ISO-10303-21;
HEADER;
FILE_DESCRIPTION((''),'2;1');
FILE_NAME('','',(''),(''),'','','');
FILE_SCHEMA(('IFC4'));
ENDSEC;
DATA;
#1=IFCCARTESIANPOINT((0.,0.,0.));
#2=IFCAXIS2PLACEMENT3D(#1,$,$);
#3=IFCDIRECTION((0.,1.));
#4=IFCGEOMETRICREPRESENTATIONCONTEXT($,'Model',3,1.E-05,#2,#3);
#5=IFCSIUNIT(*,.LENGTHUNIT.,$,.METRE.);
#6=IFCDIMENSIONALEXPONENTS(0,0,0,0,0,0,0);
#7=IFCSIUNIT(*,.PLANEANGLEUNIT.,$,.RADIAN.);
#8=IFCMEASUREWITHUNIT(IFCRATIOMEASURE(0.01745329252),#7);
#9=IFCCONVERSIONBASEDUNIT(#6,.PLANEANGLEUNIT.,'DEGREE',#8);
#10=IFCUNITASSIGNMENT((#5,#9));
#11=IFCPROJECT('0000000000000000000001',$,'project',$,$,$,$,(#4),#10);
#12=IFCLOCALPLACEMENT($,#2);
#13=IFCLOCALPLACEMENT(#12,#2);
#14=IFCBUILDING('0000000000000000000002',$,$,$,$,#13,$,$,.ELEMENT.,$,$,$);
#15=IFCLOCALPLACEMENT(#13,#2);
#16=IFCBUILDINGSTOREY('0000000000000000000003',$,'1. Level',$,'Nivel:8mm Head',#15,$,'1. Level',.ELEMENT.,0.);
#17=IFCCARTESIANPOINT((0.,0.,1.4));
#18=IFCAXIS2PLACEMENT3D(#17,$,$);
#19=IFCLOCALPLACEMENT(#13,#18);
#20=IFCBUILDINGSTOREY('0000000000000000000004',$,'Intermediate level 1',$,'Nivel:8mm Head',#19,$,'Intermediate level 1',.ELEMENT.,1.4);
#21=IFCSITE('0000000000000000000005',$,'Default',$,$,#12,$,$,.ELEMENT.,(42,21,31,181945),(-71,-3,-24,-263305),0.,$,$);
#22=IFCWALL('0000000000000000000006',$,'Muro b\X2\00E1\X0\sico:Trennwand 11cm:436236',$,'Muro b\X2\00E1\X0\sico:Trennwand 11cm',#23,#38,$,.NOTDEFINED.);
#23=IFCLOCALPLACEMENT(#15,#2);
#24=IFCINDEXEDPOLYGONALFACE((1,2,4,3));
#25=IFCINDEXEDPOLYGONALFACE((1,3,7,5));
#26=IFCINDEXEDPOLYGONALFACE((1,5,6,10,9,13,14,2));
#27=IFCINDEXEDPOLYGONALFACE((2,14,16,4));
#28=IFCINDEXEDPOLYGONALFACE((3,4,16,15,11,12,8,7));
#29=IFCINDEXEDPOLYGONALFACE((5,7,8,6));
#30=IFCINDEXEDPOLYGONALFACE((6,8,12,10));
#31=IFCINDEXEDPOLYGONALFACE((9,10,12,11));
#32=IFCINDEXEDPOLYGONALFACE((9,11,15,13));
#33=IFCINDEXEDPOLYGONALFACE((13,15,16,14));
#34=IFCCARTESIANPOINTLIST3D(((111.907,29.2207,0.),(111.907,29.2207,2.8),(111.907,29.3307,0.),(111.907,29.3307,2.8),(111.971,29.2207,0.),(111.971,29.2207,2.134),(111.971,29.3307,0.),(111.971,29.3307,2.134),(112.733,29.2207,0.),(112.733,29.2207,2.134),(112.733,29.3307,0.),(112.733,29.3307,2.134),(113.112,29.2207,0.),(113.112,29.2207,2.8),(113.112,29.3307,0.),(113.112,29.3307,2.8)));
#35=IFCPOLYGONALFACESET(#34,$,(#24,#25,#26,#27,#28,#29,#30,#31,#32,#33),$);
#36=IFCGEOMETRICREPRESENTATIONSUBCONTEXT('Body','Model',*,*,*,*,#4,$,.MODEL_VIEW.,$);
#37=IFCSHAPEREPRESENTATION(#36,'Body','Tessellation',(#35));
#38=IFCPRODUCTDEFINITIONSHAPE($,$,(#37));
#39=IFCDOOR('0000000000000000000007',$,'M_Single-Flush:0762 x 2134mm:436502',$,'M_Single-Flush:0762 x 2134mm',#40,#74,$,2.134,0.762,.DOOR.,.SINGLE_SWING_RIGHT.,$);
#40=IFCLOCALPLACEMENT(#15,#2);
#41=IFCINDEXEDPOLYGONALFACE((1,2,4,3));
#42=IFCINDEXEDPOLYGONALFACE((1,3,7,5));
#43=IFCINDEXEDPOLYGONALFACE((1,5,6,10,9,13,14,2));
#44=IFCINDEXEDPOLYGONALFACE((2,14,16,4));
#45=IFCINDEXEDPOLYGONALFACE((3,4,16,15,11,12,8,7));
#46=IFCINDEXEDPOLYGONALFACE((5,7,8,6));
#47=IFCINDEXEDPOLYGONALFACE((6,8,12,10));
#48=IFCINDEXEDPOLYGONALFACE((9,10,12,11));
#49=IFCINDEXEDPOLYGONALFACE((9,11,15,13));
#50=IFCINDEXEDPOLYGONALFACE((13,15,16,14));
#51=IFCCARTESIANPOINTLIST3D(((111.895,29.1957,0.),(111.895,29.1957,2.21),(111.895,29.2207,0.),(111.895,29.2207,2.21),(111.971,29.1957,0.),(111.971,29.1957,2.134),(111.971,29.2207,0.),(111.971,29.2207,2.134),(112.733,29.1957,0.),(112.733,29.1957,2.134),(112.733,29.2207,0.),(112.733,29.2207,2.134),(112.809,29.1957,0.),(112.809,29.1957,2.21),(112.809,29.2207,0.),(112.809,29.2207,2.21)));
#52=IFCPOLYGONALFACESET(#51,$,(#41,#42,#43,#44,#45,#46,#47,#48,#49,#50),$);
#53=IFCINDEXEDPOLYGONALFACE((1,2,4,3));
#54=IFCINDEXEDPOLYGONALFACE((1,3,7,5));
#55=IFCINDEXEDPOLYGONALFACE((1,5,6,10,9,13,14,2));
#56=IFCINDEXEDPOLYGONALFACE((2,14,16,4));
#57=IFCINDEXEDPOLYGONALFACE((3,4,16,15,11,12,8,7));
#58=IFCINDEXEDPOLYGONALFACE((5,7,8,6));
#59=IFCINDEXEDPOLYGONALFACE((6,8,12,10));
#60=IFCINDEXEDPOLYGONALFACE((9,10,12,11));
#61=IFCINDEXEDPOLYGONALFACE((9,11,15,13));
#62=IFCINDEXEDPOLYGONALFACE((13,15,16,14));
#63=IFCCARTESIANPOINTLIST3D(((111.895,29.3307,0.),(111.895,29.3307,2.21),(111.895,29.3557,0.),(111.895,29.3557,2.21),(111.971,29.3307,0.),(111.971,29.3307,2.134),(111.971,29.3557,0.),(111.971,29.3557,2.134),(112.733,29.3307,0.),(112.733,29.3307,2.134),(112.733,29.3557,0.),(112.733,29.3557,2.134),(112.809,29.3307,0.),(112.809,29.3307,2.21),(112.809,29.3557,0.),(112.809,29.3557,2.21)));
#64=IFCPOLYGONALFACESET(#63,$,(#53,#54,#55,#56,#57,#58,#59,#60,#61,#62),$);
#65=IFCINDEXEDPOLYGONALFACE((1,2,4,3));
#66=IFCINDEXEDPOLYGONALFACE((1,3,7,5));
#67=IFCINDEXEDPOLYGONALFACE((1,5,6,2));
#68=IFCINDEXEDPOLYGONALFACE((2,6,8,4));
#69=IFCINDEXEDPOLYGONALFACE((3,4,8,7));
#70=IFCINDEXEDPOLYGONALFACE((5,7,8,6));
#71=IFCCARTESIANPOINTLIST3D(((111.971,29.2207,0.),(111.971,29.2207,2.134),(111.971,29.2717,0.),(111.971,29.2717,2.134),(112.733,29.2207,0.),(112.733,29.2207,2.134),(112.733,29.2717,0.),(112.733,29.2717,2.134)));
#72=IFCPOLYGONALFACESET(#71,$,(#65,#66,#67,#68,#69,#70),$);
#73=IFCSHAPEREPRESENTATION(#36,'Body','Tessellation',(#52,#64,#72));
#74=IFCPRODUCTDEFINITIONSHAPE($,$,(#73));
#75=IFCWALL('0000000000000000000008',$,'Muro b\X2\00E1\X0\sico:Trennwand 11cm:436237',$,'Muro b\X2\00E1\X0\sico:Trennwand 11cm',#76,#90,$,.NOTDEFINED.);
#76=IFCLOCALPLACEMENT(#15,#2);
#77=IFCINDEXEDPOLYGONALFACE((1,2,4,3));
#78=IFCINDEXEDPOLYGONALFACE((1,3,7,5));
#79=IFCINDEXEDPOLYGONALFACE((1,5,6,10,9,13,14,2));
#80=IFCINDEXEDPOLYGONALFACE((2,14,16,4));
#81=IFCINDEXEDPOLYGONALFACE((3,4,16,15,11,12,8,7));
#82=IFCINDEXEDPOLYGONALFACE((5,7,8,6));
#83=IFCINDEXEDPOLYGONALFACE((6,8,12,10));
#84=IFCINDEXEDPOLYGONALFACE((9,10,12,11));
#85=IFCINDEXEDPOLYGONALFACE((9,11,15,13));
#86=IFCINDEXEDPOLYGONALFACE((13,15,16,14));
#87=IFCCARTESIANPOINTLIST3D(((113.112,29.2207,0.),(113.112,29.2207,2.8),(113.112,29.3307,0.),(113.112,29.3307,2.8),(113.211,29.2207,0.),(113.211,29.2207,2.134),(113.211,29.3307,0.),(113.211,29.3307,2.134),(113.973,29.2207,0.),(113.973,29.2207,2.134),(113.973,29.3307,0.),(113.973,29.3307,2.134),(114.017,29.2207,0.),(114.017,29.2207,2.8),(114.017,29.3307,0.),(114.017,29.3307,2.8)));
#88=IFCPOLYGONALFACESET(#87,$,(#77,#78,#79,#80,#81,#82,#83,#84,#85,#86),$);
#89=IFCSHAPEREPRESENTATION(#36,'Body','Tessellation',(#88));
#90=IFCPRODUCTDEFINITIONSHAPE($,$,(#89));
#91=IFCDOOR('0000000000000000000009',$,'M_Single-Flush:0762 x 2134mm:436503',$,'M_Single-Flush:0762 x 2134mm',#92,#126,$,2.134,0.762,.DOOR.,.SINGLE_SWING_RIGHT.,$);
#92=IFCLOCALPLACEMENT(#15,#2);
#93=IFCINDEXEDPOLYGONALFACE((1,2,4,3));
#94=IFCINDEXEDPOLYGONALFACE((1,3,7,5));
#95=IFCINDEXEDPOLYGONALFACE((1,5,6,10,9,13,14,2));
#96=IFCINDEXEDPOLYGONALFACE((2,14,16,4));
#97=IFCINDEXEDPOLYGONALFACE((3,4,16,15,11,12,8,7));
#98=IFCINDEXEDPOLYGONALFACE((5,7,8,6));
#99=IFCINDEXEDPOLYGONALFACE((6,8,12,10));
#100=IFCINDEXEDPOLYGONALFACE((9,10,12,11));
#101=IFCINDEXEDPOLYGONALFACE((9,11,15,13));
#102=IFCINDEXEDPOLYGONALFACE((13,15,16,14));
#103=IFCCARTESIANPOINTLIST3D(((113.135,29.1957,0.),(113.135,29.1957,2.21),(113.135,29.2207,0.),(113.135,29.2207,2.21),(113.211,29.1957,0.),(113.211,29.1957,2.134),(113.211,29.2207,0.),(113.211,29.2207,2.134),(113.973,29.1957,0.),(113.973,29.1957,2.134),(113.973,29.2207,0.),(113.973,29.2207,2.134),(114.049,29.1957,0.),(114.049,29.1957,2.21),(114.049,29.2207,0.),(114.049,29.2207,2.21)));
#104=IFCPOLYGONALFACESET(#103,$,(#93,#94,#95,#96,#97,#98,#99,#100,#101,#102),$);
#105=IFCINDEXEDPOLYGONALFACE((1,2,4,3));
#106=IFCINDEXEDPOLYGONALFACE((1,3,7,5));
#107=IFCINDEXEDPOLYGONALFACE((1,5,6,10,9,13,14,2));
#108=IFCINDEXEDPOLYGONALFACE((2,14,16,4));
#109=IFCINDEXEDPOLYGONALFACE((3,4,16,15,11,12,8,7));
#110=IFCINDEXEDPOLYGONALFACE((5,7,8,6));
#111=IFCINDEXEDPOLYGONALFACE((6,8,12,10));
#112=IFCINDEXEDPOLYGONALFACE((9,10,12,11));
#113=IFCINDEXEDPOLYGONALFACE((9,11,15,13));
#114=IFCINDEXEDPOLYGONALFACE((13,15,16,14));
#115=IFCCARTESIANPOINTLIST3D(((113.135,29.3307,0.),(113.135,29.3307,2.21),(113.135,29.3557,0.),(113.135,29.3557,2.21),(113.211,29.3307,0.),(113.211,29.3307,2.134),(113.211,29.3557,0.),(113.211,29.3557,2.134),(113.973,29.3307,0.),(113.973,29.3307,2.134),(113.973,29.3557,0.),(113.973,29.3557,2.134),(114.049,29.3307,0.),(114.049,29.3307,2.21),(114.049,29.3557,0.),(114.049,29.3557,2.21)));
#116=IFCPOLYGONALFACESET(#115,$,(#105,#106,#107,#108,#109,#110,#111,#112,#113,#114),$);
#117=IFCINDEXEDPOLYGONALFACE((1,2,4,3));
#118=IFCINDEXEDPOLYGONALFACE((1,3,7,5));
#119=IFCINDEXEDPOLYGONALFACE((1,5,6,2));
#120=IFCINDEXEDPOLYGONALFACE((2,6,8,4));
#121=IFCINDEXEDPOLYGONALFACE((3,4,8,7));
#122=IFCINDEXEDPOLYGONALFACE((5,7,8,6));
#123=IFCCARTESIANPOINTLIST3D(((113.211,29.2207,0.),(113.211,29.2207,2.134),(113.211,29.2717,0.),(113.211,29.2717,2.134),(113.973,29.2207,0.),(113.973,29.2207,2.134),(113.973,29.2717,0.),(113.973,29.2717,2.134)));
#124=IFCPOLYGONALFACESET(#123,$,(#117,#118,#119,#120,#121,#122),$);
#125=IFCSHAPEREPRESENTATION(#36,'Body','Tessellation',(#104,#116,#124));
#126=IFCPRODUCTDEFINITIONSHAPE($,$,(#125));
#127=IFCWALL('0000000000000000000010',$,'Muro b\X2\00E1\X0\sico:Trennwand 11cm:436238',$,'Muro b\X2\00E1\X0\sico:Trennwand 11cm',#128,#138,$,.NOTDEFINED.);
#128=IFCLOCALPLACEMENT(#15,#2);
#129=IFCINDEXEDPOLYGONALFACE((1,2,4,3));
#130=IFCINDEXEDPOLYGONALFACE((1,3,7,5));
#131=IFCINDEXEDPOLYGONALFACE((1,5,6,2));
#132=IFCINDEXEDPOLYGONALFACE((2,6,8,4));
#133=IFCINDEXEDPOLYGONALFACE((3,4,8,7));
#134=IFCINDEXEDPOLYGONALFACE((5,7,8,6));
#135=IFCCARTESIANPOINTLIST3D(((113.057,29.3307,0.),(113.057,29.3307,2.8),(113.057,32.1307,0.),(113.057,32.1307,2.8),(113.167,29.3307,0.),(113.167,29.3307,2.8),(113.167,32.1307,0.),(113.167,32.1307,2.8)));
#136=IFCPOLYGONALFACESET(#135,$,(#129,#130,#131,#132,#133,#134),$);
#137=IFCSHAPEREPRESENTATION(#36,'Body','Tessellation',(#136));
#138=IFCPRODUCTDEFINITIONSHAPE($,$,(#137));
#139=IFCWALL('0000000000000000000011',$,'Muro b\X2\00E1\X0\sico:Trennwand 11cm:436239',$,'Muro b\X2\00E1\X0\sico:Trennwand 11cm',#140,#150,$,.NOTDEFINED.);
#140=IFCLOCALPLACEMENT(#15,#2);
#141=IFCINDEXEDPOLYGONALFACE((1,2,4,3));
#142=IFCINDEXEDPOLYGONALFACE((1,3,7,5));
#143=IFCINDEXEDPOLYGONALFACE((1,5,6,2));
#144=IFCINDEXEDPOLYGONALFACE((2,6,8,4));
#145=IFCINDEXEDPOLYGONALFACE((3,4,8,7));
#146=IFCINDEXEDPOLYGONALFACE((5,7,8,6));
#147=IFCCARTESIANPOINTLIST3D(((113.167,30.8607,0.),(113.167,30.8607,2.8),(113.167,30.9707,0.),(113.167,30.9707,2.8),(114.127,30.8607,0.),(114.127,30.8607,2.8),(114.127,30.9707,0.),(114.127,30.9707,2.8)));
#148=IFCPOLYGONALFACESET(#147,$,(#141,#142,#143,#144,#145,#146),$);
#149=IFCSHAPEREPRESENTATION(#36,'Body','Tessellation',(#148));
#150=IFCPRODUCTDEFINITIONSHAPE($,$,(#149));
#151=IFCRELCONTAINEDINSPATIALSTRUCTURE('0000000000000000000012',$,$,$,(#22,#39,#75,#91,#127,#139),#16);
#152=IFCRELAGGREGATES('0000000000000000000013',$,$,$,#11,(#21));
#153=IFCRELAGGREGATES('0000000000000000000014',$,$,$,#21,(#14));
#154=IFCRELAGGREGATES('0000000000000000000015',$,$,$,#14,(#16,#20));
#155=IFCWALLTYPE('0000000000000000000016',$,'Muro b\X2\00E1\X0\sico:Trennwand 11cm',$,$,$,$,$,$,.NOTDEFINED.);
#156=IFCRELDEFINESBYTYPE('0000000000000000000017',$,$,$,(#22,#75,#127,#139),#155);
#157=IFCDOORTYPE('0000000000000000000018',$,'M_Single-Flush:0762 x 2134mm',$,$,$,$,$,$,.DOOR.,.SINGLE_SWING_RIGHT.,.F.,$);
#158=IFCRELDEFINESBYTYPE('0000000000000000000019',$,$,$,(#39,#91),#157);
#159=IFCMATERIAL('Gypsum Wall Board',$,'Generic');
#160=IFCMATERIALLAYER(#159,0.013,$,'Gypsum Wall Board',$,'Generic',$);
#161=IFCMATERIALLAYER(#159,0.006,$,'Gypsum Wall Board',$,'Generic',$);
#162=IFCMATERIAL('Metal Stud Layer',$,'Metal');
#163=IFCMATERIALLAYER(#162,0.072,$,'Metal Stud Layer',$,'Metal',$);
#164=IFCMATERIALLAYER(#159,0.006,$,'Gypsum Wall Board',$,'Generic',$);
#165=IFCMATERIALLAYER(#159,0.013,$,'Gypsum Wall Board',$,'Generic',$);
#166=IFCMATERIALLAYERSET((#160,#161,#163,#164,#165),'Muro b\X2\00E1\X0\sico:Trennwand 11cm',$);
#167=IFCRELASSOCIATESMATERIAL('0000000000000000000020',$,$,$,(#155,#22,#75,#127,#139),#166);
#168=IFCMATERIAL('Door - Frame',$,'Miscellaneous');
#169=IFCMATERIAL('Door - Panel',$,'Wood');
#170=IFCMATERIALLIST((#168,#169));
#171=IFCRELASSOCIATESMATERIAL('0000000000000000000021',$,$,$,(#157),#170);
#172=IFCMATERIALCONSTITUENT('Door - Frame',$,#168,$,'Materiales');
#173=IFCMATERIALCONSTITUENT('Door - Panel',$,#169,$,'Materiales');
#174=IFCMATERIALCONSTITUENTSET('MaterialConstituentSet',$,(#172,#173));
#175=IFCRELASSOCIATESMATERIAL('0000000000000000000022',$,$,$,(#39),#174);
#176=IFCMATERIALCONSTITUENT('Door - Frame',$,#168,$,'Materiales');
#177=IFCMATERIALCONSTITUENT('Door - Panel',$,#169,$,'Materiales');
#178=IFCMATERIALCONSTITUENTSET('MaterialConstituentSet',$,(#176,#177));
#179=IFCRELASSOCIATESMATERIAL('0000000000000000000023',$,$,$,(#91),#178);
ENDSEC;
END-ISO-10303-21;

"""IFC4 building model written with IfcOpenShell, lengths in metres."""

from ifc_helpers import new_model, entity, si_unit, converted_unit, direction, frame, frame_2d, origin, origin_2d_with_axis, place, context, subcontext, project, spatial, polyline, rectangle, outline, extrude, source, transform, mapped, material, material_list, layer, layer_set, layer_usage, constituent, constituent_set, type_object, type_shapes, element, fill, save


model = new_model("IFC4")

# Units and contexts
model_context = context("Model", 3, precision=1e-05, world=origin(), true_north=direction((0.0, 1.0)))
body_context = subcontext(model_context, "Body", "Model", "MODEL_VIEW")
ifc_project = project(units=[si_unit("LENGTHUNIT", "METRE"), converted_unit("PLANEANGLEUNIT", "DEGREE", entity("IfcRatioMeasure", 0.01745329252), si_unit("PLANEANGLEUNIT", "RADIAN"), dimensions=[0, 0, 0, 0, 0, 0, 0])], contexts=[model_context])

# Site, building, storey
site_placement = place(None, origin())
site = spatial("IfcSite", under=ifc_project, at=site_placement, Name="Default", CompositionType="ELEMENT", RefLatitude=(42, 21, 31, 181945), RefLongitude=(-71, -3, -24, -263305), RefElevation=0.0)
building_placement = place(site_placement, origin())
building = spatial("IfcBuilding", under=site, at=building_placement, CompositionType="ELEMENT")
storey_1_placement = place(building_placement, origin())
storey_1 = spatial("IfcBuildingStorey", under=building, at=storey_1_placement, Name="1. Level", ObjectType="Nivel:8mm Head", LongName="1. Level", CompositionType="ELEMENT", Elevation=0.0)

# Shared definitions
storey_2_placement = place(building_placement, frame((0.0, 0.0, 1.4)))
storey_2 = spatial("IfcBuildingStorey", under=building, at=storey_2_placement, Name="Intermediate level 1", ObjectType="Nivel:8mm Head", LongName="Intermediate level 1", CompositionType="ELEMENT", Elevation=1.4)

# Shared definitions
ifc_material_1 = material(Name="Gypsum Wall Board", Category="Generic")
ifc_layer_1 = layer(ifc_material_1, 0.013, Name="Gypsum Wall Board", Category="Generic")
ifc_layer_2 = layer(ifc_material_1, 0.006, Name="Gypsum Wall Board", Category="Generic")
ifc_material_2 = material(Name="Metal Stud Layer", Category="Metal")
ifc_layer_3 = layer(ifc_material_2, 0.072, Name="Metal Stud Layer", Category="Metal")
ifc_layer_4 = layer(ifc_material_1, 0.006, Name="Gypsum Wall Board", Category="Generic")
ifc_layer_5 = layer(ifc_material_1, 0.013, Name="Gypsum Wall Board", Category="Generic")
ifc_layer_set_1 = layer_set([ifc_layer_1, ifc_layer_2, ifc_layer_3, ifc_layer_4, ifc_layer_5], Name="Muro básico:Trennwand 11cm")
wall_type_1 = type_object("IfcWallType", Name="Muro básico:Trennwand 11cm", PredefinedType="NOTDEFINED", material=ifc_layer_set_1)
ifc_material_3 = material(Name="Door - Frame", Category="Miscellaneous")
ifc_material_4 = material(Name="Door - Panel", Category="Wood")
ifc_material_list_1 = material_list([ifc_material_3, ifc_material_4])
door_type_1 = type_object("IfcDoorType", Name="M_Single-Flush:0762 x 2134mm", OperationType="SINGLE_SWING_RIGHT", ParameterTakesPrecedence=False, PredefinedType="DOOR", material=ifc_material_list_1)
shared_shape_1 = source(origin(), body_context, "Body", "SweptSolid", [
    extrude(outline(polyline([(-0.457, -1.124), (0.457, -1.124), (0.457, 1.086), (0.381, 1.086), (0.381, -1.048), (-0.381, -1.048), (-0.381, 1.086), (-0.457, 1.086), (-0.457, -1.124)])), frame((0.381, 0.11, 1.086), z_axis=(0.0, 1.0, 0.0), x_axis=(1.0, 0.0, 0.0)), (0.0, 0.0, 1.0), 0.025),
    extrude(outline(polyline([(-1.124, -0.457), (1.086, -0.457), (1.086, -0.381), (-1.048, -0.381), (-1.048, 0.381), (1.086, 0.381), (1.086, 0.457), (-1.124, 0.457), (-1.124, -0.457)])), frame((0.381, -0.025, 1.086), z_axis=(0.0, 1.0, 0.0), x_axis=(0.0, 0.0, -1.0)), (0.0, 0.0, 1.0), 0.025),
    extrude(rectangle(XDim=0.051, YDim=0.762, at=origin_2d_with_axis()), frame((0.381, 0.0845, 0.0), z_axis=(0.0, 0.0, 1.0), x_axis=(0.0, 1.0, 0.0)), (0.0, 0.0, 1.0), 2.134),
])
type_shapes(door_type_1, [shared_shape_1])

# Walls, openings, doors
ifc_layer_usage_1 = layer_usage(ifc_layer_set_1, "AXIS2", "NEGATIVE", 0.055)
wall_1_placement = place(storey_1_placement, frame((113.112, 29.2757, 0.0), z_axis=(0.0, 0.0, 1.0), x_axis=(-1.0, 0.0, 0.0)))
wall_1 = element("IfcWall", 1, at=wall_1_placement, inside=storey_1, type_object=wall_type_1, material=ifc_layer_usage_1, Name="Muro básico:Trennwand 11cm:436236", ObjectType="Muro básico:Trennwand 11cm", PredefinedType="NOTDEFINED", context=body_context, shape_type="SweptSolid", body=[
    extrude(rectangle(XDim=1.205, YDim=0.11, at=frame_2d((0.6025, 0.0), x_axis=(-1.0, 0.0))), origin(), (0.0, 0.0, 1.0), 2.8),
])
opening_1_placement = place(wall_1_placement, frame((0.379, -0.055, 0.0)))
opening_1 = element("IfcOpeningElement", 2, at=opening_1_placement, cuts=wall_1, ObjectType="Opening", PredefinedType="OPENING", context=body_context, shape_type="SweptSolid", body=[
    extrude(rectangle(XDim=0.762, YDim=2.134, at=frame_2d((1.067, 0.381), x_axis=(0.0, 1.0))), frame((0.0, 0.0, 0.0), z_axis=(0.0, 1.0, 0.0), x_axis=(0.0, 0.0, 1.0)), (0.0, 0.0, 1.0), 0.11),
])
ifc_constituent_1 = constituent(ifc_material_3, Name="Door - Frame", Category="Materiales")
ifc_constituent_2 = constituent(ifc_material_4, Name="Door - Panel", Category="Materiales")
ifc_constituent_set_1 = constituent_set(constituents=[ifc_constituent_1, ifc_constituent_2], Name="MaterialConstituentSet")
door_1_placement = place(opening_1_placement, origin())
door_1 = element("IfcDoor", 3, at=door_1_placement, inside=storey_1, type_object=door_type_1, material=ifc_constituent_set_1, Name="M_Single-Flush:0762 x 2134mm:436502", ObjectType="M_Single-Flush:0762 x 2134mm", OperationType="SINGLE_SWING_RIGHT", OverallHeight=2.134, OverallWidth=0.762, PredefinedType="DOOR", context=body_context, shape_type="MappedRepresentation", body=[
    mapped(shared_shape_1, transform((0.0, 0.0, 0.0), scale=1.0)),
])
fill(opening_1, door_1)
ifc_layer_usage_2 = layer_usage(ifc_layer_set_1, "AXIS2", "NEGATIVE", 0.055)
wall_2_placement = place(storey_1_placement, frame((113.112, 29.2757, 0.0)))
wall_2 = element("IfcWall", 4, at=wall_2_placement, inside=storey_1, type_object=wall_type_1, material=ifc_layer_usage_2, Name="Muro básico:Trennwand 11cm:436237", ObjectType="Muro básico:Trennwand 11cm", PredefinedType="NOTDEFINED", context=body_context, shape_type="SweptSolid", body=[
    extrude(rectangle(XDim=0.905, YDim=0.11, at=frame_2d((0.4525, 0.0), x_axis=(-1.0, 0.0))), origin(), (0.0, 0.0, 1.0), 2.8),
])
opening_2_placement = place(wall_2_placement, frame((0.861, 0.055, 0.0)))
opening_2 = element("IfcOpeningElement", 5, at=opening_2_placement, cuts=wall_2, ObjectType="Opening", PredefinedType="OPENING", context=body_context, shape_type="SweptSolid", body=[
    extrude(rectangle(XDim=0.762, YDim=2.134, at=frame_2d((1.067, 0.381), x_axis=(0.0, 1.0))), frame((0.0, 0.0, 0.0), z_axis=(0.0, -1.0, 0.0), x_axis=(0.0, 0.0, 1.0)), (0.0, 0.0, 1.0), 0.11),
])
ifc_constituent_3 = constituent(ifc_material_3, Name="Door - Frame", Category="Materiales")
ifc_constituent_4 = constituent(ifc_material_4, Name="Door - Panel", Category="Materiales")
ifc_constituent_set_2 = constituent_set(constituents=[ifc_constituent_3, ifc_constituent_4], Name="MaterialConstituentSet")
door_2_placement = place(opening_2_placement, frame((0.0, 0.0, 0.0), z_axis=(0.0, 0.0, 1.0), x_axis=(-1.0, 0.0, 0.0)))
door_2 = element("IfcDoor", 6, at=door_2_placement, inside=storey_1, type_object=door_type_1, material=ifc_constituent_set_2, Name="M_Single-Flush:0762 x 2134mm:436503", ObjectType="M_Single-Flush:0762 x 2134mm", OperationType="SINGLE_SWING_RIGHT", OverallHeight=2.134, OverallWidth=0.762, PredefinedType="DOOR", context=body_context, shape_type="MappedRepresentation", body=[
    mapped(shared_shape_1, transform((0.0, 0.0, 0.0), scale=1.0)),
])
fill(opening_2, door_2)

# Walls
ifc_layer_usage_3 = layer_usage(ifc_layer_set_1, "AXIS2", "NEGATIVE", 0.055)
wall_3_placement = place(storey_1_placement, frame((113.112, 32.1307, 0.0), z_axis=(0.0, 0.0, 1.0), x_axis=(0.0, -1.0, 0.0)))
element("IfcWall", 7, at=wall_3_placement, inside=storey_1, type_object=wall_type_1, material=ifc_layer_usage_3, Name="Muro básico:Trennwand 11cm:436238", ObjectType="Muro básico:Trennwand 11cm", PredefinedType="NOTDEFINED", context=body_context, shape_type="SweptSolid", body=[
    extrude(rectangle(XDim=2.8, YDim=0.11, at=frame_2d((1.4, 0.0), x_axis=(-1.0, 0.0))), origin(), (0.0, 0.0, 1.0), 2.8),
])
ifc_layer_usage_4 = layer_usage(ifc_layer_set_1, "AXIS2", "NEGATIVE", 0.055)
wall_4_placement = place(storey_1_placement, frame((113.167, 30.9157, 0.0)))
element("IfcWall", 8, at=wall_4_placement, inside=storey_1, type_object=wall_type_1, material=ifc_layer_usage_4, Name="Muro básico:Trennwand 11cm:436239", ObjectType="Muro básico:Trennwand 11cm", PredefinedType="NOTDEFINED", context=body_context, shape_type="SweptSolid", body=[
    extrude(rectangle(XDim=0.96, YDim=0.11, at=frame_2d((0.48, 0.0), x_axis=(-1.0, 0.0))), origin(), (0.0, 0.0, 1.0), 2.8),
])

save(model, "model.ifc")
